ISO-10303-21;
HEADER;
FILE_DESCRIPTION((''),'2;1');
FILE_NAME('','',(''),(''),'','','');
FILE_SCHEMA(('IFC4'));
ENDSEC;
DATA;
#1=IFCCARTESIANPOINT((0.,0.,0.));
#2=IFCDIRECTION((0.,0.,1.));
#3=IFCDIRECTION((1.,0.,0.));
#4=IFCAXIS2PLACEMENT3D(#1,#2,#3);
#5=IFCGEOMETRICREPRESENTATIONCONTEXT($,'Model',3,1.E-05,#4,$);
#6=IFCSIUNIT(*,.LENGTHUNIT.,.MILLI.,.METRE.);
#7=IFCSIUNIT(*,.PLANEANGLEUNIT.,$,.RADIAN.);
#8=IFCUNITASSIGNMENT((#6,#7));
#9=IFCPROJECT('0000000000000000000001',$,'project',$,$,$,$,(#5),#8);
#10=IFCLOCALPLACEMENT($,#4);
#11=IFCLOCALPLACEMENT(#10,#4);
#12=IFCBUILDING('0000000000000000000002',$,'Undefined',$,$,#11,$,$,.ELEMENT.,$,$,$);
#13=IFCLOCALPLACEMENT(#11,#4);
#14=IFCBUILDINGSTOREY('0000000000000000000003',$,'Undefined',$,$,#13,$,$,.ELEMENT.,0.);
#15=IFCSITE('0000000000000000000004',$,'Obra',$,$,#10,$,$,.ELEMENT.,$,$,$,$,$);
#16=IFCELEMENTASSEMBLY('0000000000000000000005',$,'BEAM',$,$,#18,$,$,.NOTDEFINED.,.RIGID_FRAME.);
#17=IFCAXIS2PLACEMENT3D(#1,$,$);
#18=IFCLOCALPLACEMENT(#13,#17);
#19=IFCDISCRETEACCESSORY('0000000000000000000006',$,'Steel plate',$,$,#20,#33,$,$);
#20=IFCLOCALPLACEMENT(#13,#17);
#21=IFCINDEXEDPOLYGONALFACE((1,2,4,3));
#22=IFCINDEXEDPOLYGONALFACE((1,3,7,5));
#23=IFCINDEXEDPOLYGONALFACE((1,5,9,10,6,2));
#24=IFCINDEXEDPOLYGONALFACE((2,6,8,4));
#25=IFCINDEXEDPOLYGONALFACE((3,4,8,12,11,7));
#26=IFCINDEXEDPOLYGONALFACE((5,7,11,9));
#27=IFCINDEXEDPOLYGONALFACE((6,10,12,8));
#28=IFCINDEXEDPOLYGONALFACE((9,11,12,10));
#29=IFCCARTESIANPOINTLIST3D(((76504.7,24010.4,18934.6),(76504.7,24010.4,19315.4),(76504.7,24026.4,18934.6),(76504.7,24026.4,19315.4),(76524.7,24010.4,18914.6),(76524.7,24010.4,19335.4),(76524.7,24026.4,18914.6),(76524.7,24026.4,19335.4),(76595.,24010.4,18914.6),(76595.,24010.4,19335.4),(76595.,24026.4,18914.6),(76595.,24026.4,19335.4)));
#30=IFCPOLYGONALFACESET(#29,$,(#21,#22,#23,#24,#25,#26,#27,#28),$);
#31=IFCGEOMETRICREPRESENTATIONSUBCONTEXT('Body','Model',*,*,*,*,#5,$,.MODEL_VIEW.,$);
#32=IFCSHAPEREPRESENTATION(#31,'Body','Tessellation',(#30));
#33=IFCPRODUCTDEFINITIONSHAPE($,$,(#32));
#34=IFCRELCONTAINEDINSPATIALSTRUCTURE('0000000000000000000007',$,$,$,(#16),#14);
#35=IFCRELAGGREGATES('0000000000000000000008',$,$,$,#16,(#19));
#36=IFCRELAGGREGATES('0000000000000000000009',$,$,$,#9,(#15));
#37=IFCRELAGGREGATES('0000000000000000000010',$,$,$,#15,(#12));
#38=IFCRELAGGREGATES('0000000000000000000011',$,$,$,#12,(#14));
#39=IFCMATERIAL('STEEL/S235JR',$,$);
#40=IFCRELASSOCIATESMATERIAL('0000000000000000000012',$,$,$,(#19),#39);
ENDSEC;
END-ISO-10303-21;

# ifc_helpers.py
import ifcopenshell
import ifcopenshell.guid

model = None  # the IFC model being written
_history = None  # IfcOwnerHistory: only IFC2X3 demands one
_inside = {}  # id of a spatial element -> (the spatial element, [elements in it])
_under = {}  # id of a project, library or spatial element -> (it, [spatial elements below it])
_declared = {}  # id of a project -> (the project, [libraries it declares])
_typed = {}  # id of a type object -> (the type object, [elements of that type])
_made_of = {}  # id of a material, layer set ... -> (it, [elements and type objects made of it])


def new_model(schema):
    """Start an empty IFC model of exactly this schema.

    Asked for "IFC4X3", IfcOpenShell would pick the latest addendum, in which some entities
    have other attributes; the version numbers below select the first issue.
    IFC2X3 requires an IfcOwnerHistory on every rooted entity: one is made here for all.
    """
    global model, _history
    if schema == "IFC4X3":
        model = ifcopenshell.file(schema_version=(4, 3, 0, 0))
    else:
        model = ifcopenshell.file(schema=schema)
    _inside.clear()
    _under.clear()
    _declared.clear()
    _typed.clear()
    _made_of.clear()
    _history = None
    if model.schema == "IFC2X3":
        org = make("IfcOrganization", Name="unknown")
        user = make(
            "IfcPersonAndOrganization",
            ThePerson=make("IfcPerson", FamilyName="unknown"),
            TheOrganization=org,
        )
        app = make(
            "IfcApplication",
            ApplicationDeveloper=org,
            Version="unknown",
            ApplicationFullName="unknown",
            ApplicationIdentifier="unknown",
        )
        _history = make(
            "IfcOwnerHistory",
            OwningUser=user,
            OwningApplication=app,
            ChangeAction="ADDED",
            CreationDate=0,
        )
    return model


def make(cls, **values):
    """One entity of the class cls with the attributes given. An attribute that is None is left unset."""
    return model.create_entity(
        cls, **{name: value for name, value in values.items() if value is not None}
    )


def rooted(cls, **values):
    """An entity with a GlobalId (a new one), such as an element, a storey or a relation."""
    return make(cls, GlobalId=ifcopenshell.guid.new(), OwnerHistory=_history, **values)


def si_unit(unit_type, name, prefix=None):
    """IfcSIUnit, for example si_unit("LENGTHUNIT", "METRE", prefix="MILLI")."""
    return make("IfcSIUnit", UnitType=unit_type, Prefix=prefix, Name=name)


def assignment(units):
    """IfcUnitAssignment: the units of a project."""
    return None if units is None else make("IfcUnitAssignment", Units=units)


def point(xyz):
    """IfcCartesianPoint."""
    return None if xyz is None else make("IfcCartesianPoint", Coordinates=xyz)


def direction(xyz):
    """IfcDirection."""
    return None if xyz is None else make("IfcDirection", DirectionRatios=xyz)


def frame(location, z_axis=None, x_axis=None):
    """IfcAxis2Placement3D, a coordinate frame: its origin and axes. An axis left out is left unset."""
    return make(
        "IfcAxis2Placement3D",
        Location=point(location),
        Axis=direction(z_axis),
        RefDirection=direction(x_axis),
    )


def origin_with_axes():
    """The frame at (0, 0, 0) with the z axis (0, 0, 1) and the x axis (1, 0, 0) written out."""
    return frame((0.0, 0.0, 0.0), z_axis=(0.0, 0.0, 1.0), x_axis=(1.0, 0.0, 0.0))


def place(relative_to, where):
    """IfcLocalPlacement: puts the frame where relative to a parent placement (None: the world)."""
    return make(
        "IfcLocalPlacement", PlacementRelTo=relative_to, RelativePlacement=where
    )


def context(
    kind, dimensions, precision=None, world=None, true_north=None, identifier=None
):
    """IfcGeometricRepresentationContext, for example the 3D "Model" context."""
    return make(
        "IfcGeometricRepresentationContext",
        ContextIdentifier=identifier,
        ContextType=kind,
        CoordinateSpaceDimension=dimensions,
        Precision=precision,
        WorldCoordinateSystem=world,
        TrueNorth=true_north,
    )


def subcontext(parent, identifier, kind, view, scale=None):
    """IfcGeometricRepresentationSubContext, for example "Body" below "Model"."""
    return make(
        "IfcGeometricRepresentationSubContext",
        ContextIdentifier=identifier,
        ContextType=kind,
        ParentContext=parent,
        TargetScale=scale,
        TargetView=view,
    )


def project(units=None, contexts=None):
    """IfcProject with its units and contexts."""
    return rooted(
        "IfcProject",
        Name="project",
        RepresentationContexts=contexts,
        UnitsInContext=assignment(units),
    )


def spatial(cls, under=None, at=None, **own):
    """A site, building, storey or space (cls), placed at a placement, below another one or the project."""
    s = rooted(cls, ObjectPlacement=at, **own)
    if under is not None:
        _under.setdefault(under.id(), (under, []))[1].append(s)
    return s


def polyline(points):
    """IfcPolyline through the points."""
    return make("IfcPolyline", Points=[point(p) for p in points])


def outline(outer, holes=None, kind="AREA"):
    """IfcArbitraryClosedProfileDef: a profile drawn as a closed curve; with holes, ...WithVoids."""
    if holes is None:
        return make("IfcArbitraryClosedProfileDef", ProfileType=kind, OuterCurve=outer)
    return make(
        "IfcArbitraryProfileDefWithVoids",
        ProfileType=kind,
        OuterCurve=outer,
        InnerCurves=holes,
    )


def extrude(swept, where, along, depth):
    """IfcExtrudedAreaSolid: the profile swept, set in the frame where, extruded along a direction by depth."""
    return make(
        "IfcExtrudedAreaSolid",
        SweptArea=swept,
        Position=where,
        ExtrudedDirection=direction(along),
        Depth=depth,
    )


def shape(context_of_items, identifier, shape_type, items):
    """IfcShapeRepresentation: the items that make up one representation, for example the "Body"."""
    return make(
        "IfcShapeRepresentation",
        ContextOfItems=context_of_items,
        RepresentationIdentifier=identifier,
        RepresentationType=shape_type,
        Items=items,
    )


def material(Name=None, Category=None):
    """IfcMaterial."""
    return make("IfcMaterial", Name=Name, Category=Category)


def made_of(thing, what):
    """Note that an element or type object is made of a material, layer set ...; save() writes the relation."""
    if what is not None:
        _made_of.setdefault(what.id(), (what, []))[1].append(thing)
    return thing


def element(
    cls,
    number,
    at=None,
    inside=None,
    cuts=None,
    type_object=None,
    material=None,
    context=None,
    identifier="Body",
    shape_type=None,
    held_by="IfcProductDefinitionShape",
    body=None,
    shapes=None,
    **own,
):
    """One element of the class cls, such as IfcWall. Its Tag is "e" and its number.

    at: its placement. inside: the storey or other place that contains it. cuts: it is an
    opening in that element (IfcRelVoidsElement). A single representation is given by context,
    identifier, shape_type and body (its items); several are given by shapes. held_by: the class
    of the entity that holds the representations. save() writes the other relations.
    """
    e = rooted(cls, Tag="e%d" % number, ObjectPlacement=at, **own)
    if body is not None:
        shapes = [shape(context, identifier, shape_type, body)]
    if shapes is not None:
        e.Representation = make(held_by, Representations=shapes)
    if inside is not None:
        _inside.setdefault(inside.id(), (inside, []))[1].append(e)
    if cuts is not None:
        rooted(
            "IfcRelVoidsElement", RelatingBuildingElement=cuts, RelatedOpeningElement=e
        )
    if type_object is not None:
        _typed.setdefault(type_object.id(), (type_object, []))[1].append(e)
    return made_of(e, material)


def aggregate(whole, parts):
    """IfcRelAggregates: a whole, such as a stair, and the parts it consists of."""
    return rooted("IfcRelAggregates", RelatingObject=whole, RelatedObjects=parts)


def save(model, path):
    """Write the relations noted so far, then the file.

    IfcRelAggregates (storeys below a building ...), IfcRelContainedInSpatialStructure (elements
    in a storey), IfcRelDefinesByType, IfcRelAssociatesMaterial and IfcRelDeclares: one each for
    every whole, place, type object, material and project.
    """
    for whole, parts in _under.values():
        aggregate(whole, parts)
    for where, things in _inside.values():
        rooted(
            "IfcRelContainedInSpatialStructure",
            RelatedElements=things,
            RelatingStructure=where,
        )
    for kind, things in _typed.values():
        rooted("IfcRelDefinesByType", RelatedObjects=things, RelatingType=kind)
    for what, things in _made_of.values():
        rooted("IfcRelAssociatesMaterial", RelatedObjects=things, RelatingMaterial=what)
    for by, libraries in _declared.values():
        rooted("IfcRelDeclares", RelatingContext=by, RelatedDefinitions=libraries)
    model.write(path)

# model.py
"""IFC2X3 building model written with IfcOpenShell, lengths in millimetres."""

from ifc_helpers import new_model, si_unit, frame, origin_with_axes, place, context, subcontext, project, spatial, polyline, outline, extrude, material, element, aggregate, save


model = new_model("IFC2X3")

# Units and contexts
model_context = context("Model", 3, precision=1e-05, world=origin_with_axes())
body_context = subcontext(model_context, "Body", "Model", "MODEL_VIEW")
ifc_project = project(units=[si_unit("LENGTHUNIT", "METRE", prefix="MILLI"), si_unit("PLANEANGLEUNIT", "RADIAN")], contexts=[model_context])

# Site, building, storey
site_placement = place(None, origin_with_axes())
site = spatial("IfcSite", under=ifc_project, at=site_placement, Name="Obra", CompositionType="ELEMENT")
building_placement = place(site_placement, origin_with_axes())
building = spatial("IfcBuilding", under=site, at=building_placement, Name="Undefined", CompositionType="ELEMENT")
storey_placement = place(building_placement, origin_with_axes())
storey = spatial("IfcBuildingStorey", under=building, at=storey_placement, Name="Undefined", CompositionType="ELEMENT", Elevation=0.0)

# Shared definitions
ifc_material_1 = material(Name="STEEL/S235JR")

# Element assembly
assembly_1_placement = place(storey_placement, origin_with_axes())
assembly_1 = element("IfcElementAssembly", 1, at=assembly_1_placement, inside=storey, Name="BEAM", AssemblyPlace="NOTDEFINED", PredefinedType="RIGID_FRAME")

# Discrete accessory
discrete_accessory_1_placement = place(assembly_1_placement, frame((76595.0, 24018.4, 19335.4), z_axis=(0.000003, -1.0, 0.0), x_axis=(-1.0, -0.000004, 0.0)))
discrete_accessory_1 = element("IfcDiscreteAccessory", 2, at=discrete_accessory_1_placement, material=ifc_material_1, Name="Steel plate", context=body_context, shape_type="SweptSolid", body=[
    extrude(outline(polyline([(0.0, 0.0), (70.3, 0.0), (90.3, 20.0), (90.3, 400.8), (70.3, 420.8), (0.0, 420.8), (0.0, 0.0)])), frame((0.0, 0.0, -8.0), z_axis=(0.0, 0.0, 1.0), x_axis=(1.0, 0.0, 0.0)), (0.0, 0.0, 1.0), 16.0),
])
aggregate(assembly_1, [discrete_accessory_1])

save(model, "model.ifc")
